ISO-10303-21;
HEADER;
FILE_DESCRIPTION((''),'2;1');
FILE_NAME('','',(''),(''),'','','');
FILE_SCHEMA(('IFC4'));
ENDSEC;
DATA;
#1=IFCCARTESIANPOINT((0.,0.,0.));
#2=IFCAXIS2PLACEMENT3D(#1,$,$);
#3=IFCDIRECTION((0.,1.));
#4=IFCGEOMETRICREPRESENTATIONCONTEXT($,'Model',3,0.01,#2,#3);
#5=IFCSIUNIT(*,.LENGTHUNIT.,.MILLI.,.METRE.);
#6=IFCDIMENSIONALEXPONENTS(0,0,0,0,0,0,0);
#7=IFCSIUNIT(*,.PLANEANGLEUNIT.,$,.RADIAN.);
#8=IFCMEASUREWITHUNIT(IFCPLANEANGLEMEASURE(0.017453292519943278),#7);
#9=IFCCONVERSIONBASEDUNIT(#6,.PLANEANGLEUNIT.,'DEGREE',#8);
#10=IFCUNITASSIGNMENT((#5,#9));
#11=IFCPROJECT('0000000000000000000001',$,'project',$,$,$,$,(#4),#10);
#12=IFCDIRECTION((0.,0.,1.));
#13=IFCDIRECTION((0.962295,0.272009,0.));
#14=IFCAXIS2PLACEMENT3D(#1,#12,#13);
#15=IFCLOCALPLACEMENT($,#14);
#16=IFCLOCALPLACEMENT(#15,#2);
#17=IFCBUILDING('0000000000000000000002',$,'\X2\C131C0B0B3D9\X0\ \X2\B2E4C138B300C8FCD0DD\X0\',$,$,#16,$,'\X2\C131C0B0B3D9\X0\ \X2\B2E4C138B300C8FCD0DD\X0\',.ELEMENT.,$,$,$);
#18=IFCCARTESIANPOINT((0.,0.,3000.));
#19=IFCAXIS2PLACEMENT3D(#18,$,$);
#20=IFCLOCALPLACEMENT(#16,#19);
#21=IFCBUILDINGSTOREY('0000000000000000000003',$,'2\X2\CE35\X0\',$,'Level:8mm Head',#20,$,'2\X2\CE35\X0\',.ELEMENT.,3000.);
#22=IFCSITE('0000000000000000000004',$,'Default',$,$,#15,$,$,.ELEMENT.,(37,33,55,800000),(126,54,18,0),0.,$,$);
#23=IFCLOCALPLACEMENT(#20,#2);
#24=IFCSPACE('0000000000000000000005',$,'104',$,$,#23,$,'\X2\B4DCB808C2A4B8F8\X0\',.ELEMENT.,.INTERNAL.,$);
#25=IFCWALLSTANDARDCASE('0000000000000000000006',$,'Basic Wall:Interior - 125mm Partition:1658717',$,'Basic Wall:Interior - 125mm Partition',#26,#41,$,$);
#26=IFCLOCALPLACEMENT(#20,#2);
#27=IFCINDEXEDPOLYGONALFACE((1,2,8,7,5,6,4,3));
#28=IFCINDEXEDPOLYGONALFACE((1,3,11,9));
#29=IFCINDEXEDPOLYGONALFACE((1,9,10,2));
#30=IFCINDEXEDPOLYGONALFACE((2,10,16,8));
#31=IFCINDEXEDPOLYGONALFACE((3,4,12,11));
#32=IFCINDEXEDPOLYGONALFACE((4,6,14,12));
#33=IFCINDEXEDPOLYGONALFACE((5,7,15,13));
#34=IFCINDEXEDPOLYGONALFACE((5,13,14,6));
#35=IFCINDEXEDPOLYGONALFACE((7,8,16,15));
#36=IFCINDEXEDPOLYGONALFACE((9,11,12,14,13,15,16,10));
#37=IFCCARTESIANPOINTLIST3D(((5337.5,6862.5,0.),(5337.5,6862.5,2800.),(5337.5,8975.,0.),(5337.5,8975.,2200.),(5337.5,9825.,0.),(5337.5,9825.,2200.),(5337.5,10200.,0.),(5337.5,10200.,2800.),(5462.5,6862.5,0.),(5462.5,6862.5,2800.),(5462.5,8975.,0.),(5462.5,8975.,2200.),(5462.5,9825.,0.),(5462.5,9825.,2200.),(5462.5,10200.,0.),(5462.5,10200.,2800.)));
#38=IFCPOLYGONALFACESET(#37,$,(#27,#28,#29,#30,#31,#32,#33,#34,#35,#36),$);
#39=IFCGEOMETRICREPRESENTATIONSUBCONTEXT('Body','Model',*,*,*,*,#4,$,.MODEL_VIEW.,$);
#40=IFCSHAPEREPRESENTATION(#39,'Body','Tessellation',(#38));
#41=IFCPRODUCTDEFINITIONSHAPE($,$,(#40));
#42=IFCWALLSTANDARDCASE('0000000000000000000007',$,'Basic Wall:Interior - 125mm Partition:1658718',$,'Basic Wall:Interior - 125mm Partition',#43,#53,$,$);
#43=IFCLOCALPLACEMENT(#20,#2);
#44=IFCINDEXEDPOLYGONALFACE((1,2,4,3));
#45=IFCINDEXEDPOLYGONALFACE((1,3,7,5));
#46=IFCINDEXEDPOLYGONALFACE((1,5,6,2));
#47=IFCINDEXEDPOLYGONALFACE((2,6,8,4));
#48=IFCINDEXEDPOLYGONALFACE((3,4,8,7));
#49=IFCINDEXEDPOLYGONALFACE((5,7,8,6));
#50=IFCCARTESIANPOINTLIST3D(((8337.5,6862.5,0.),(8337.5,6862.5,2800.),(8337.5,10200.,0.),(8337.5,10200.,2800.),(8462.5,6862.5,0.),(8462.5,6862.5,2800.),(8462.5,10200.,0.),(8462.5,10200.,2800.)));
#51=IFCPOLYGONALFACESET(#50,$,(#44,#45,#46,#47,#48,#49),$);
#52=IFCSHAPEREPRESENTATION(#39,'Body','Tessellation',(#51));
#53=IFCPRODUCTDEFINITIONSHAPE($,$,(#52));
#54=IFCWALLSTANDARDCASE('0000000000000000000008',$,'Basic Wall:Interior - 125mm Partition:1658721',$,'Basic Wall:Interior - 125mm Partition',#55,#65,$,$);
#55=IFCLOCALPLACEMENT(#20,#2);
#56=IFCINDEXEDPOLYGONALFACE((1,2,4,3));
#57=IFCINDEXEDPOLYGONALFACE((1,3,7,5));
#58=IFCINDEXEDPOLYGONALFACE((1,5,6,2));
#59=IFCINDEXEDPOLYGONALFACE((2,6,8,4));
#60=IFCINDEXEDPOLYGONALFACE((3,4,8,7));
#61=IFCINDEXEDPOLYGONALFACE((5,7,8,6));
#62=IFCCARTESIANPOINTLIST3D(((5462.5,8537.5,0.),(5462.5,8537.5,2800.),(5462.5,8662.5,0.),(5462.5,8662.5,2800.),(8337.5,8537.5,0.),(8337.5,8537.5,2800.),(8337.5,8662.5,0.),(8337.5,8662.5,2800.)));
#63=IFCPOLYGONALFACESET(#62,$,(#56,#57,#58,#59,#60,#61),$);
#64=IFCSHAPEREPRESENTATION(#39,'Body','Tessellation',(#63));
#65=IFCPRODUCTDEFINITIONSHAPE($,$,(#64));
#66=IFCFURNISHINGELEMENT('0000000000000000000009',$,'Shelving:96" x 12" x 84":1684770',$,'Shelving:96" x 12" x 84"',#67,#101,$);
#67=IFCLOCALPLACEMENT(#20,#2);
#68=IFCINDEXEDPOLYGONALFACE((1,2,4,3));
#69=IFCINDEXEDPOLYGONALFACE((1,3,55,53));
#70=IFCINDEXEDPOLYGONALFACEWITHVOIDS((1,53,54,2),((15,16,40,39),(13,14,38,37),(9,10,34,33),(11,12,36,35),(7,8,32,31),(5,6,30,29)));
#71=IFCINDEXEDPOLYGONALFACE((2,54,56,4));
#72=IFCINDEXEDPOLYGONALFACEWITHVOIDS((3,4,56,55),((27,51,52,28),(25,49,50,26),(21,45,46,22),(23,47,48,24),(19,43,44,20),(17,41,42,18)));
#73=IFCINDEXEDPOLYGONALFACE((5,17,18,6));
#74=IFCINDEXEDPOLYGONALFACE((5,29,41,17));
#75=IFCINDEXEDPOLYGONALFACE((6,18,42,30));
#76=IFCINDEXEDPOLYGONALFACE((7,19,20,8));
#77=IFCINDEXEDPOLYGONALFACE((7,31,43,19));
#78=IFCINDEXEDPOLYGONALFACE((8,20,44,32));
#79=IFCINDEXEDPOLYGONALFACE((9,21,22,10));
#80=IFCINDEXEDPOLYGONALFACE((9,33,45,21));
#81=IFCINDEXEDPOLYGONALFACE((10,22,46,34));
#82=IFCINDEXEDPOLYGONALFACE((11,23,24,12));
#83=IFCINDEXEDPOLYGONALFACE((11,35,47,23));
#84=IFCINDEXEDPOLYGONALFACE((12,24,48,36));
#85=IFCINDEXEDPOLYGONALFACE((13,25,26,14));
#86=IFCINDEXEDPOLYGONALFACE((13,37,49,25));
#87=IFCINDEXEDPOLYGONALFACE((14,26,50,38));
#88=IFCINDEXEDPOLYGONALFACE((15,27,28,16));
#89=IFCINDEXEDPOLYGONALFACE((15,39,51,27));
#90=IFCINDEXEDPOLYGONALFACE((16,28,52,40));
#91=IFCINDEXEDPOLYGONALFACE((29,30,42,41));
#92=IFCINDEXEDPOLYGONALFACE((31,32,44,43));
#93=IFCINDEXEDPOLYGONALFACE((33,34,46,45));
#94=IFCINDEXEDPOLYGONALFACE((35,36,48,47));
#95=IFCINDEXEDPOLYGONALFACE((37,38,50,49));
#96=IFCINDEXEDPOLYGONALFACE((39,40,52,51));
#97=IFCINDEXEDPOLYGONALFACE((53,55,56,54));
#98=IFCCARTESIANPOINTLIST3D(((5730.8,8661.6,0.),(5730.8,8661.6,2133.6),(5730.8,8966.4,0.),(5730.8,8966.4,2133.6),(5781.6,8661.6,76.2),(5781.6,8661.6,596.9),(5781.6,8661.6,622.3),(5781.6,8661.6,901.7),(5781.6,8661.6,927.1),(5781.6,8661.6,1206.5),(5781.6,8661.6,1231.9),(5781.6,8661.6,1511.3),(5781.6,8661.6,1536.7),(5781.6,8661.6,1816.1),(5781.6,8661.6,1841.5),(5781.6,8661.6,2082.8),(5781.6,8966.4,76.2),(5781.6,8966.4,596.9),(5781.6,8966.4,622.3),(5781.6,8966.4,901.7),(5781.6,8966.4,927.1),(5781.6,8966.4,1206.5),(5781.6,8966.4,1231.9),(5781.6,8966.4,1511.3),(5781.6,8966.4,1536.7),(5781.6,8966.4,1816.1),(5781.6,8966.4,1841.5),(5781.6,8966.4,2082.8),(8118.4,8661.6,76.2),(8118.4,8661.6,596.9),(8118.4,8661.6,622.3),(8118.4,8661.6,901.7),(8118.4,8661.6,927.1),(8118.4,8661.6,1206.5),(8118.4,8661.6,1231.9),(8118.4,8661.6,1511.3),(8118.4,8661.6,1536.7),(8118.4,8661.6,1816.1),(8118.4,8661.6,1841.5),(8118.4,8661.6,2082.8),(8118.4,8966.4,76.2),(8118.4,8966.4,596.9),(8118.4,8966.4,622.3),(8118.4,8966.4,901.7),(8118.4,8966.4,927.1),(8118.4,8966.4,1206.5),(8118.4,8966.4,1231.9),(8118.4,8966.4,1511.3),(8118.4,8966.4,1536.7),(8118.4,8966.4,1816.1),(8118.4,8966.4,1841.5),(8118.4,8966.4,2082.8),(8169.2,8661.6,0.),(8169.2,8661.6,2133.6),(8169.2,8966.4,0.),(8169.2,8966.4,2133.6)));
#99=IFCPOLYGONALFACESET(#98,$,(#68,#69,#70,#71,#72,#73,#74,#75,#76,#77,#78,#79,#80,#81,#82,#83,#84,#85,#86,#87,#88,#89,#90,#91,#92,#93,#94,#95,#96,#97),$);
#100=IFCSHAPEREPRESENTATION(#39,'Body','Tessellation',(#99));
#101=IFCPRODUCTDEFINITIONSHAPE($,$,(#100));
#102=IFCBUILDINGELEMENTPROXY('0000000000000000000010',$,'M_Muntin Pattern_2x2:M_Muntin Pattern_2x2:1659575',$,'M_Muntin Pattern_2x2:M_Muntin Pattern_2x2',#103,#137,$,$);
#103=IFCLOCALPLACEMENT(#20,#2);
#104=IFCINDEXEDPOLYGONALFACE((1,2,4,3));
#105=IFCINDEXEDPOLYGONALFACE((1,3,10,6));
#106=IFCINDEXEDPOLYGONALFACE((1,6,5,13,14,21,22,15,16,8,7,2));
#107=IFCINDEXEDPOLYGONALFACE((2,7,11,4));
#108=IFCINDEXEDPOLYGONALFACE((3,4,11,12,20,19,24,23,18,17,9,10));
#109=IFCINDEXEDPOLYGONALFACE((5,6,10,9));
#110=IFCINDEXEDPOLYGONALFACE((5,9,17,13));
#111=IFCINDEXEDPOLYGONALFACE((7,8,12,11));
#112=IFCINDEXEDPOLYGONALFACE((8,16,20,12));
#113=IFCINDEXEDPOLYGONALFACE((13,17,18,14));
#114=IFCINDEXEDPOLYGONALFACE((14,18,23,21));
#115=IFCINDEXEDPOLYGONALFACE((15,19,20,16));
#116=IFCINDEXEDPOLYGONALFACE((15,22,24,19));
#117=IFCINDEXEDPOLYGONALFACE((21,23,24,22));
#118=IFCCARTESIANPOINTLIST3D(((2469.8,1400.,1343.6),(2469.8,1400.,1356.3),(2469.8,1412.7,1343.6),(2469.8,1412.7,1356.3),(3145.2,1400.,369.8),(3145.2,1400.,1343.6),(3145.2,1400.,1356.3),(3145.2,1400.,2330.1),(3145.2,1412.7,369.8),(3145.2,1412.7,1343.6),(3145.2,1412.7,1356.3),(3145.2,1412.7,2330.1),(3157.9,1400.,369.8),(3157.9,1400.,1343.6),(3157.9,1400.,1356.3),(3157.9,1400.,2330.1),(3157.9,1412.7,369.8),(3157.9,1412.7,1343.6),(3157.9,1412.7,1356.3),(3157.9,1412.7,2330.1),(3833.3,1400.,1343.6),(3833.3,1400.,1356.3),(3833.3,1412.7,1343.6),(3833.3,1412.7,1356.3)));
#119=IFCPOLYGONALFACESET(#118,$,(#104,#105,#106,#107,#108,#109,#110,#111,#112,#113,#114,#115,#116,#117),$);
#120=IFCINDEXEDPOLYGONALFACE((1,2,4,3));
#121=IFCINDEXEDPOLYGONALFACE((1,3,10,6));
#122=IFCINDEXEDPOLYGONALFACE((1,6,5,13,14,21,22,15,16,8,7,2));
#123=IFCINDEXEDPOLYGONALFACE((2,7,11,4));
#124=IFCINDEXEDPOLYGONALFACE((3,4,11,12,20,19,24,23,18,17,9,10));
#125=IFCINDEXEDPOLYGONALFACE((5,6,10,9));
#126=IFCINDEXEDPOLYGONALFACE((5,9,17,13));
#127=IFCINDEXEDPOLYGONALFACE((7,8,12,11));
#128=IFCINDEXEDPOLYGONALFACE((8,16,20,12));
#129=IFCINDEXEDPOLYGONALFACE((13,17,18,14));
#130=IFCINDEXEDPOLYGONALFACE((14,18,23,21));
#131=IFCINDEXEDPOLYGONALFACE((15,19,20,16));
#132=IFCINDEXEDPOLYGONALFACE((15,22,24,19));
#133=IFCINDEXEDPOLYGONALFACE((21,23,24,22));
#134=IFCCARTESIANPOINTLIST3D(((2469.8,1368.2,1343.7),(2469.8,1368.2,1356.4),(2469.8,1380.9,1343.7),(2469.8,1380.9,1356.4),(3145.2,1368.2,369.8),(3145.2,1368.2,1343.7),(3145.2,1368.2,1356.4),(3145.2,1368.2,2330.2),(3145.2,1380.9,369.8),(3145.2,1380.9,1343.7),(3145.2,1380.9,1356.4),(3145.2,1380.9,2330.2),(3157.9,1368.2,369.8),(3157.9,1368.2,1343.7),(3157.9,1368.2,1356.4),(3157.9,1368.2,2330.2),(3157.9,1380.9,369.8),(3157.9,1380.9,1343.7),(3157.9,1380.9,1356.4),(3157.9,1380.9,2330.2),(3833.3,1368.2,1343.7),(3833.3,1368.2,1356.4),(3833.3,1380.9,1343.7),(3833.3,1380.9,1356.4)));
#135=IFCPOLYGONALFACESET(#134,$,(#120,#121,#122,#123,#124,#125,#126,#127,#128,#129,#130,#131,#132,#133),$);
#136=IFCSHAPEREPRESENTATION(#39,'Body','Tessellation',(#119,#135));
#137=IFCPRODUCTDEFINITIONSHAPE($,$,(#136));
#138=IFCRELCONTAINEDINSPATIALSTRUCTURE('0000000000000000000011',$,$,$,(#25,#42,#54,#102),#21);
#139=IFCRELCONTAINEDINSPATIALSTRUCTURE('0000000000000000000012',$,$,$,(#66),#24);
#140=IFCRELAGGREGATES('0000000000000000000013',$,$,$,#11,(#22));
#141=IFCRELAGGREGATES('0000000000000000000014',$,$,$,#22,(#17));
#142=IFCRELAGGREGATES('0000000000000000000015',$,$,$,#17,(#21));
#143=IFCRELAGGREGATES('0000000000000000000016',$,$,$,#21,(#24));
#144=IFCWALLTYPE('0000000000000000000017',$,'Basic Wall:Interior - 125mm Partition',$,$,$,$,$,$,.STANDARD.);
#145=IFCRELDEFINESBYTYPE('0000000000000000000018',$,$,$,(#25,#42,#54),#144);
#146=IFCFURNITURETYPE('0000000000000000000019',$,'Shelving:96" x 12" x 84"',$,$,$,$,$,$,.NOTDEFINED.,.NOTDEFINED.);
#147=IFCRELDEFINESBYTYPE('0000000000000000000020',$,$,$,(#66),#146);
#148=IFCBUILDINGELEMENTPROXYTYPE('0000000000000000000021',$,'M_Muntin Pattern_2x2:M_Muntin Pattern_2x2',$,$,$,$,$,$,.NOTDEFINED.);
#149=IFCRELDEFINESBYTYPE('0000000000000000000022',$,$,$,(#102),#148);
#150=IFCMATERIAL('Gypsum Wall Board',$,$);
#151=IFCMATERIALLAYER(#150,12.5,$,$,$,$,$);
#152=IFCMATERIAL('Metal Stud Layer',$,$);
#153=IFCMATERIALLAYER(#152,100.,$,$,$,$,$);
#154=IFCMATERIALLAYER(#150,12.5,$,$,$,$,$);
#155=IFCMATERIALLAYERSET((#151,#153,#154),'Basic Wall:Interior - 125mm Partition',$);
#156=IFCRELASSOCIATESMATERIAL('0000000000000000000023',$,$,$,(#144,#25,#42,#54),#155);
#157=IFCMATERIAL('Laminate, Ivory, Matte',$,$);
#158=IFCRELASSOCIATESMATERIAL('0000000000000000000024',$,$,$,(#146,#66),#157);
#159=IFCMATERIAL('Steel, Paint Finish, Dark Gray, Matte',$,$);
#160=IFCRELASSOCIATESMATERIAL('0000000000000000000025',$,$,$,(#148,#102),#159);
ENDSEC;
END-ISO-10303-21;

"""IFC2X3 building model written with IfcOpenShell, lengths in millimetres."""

from ifc_helpers import new_model, entity, si_unit, converted_unit, direction, frame, frame_2d, origin, place, context, subcontext, project, spatial, polyline, rectangle, outline, extrude, source, transform, mapped, material, layer, layer_set, layer_usage, type_object, type_shapes, element, save


model = new_model("IFC2X3")

# Units and contexts
model_context = context("Model", 3, precision=0.01, world=origin(), true_north=direction((0.0, 1.0)))
body_context = subcontext(model_context, "Body", "Model", "MODEL_VIEW")
ifc_project = project(units=[si_unit("LENGTHUNIT", "METRE", prefix="MILLI"), converted_unit("PLANEANGLEUNIT", "DEGREE", entity("IfcPlaneAngleMeasure", 0.017453292519943278), si_unit("PLANEANGLEUNIT", "RADIAN"), dimensions=[0, 0, 0, 0, 0, 0, 0])], contexts=[model_context])

# Site, building, storey
site_placement = place(None, frame((0.0, 0.0, 0.0), z_axis=(0.0, 0.0, 1.0), x_axis=(0.962295, 0.272009, 0.0)))
site = spatial("IfcSite", under=ifc_project, at=site_placement, Name="Default", CompositionType="ELEMENT", RefLatitude=(37, 33, 55, 800000), RefLongitude=(126, 54, 18, 0), RefElevation=0.0)
building_placement = place(site_placement, origin())
building = spatial("IfcBuilding", under=site, at=building_placement, Name="성산동 다세대주택", LongName="성산동 다세대주택", CompositionType="ELEMENT")
storey_placement = place(building_placement, frame((0.0, 0.0, 3000.0)))
storey = spatial("IfcBuildingStorey", under=building, at=storey_placement, Name="2층", ObjectType="Level:8mm Head", LongName="2층", CompositionType="ELEMENT", Elevation=3000.0)

# Wall, opening
ifc_material_1 = material(Name="Gypsum Wall Board")
ifc_layer_1 = layer(ifc_material_1, 12.5)
ifc_material_2 = material(Name="Metal Stud Layer")
ifc_layer_2 = layer(ifc_material_2, 100.0)
ifc_layer_3 = layer(ifc_material_1, 12.5)
ifc_layer_set = layer_set([ifc_layer_1, ifc_layer_2, ifc_layer_3], Name="Basic Wall:Interior - 125mm Partition")
ifc_layer_usage_1 = layer_usage(ifc_layer_set, "AXIS2", "NEGATIVE", 62.5)
wall_type = type_object("IfcWallType", Name="Basic Wall:Interior - 125mm Partition", PredefinedType="STANDARD", material=ifc_layer_set)
wall_1_placement = place(storey_placement, frame((5400.0, 6862.5, 0.0), z_axis=(0.0, 0.0, 1.0), x_axis=(0.0, 1.0, 0.0)))
wall_1 = element("IfcWallStandardCase", 1, at=wall_1_placement, inside=storey, type_object=wall_type, material=ifc_layer_usage_1, Name="Basic Wall:Interior - 125mm Partition:1658717", ObjectType="Basic Wall:Interior - 125mm Partition", context=body_context, shape_type="SweptSolid", body=[
    extrude(rectangle(XDim=3337.5, YDim=125.0, at=frame_2d((1668.7, 0.0), x_axis=(1.0, 0.0))), origin(), (0.0, 0.0, 1.0), 2800.0),
])
opening_placement = place(wall_1_placement, frame((2112.5, -62.5, 0.0)))
element("IfcOpeningElement", 2, at=opening_placement, cuts=wall_1, ObjectType="Opening", context=body_context, shape_type="SweptSolid", body=[
    extrude(rectangle(XDim=2200.0, YDim=850.0, at=frame_2d((1100.0, 425.0), x_axis=(1.0, 0.0))), frame((0.0, 0.0, 0.0), z_axis=(0.0, 1.0, 0.0), x_axis=(0.0, 0.0, 1.0)), (0.0, 0.0, 1.0), 125.0),
])

# Walls
ifc_layer_usage_2 = layer_usage(ifc_layer_set, "AXIS2", "NEGATIVE", 62.5)
wall_2_placement = place(storey_placement, frame((8400.0, 6862.5, 0.0), z_axis=(0.0, 0.0, 1.0), x_axis=(0.0, 1.0, 0.0)))
element("IfcWallStandardCase", 3, at=wall_2_placement, inside=storey, type_object=wall_type, material=ifc_layer_usage_2, Name="Basic Wall:Interior - 125mm Partition:1658718", ObjectType="Basic Wall:Interior - 125mm Partition", context=body_context, shape_type="SweptSolid", body=[
    extrude(rectangle(XDim=3337.5, YDim=125.0, at=frame_2d((1668.7, 0.0), x_axis=(-1.0, 0.0))), origin(), (0.0, 0.0, 1.0), 2800.0),
])
ifc_layer_usage_3 = layer_usage(ifc_layer_set, "AXIS2", "NEGATIVE", 62.5)
wall_3_placement = place(storey_placement, frame((5462.5, 8600.0, 0.0)))
element("IfcWallStandardCase", 4, at=wall_3_placement, inside=storey, type_object=wall_type, material=ifc_layer_usage_3, Name="Basic Wall:Interior - 125mm Partition:1658721", ObjectType="Basic Wall:Interior - 125mm Partition", context=body_context, shape_type="SweptSolid", body=[
    extrude(rectangle(XDim=2875.0, YDim=125.0, at=frame_2d((1437.5, 0.0), x_axis=(-1.0, 0.0))), origin(), (0.0, 0.0, 1.0), 2800.0),
])

# Shared definitions
space_1_placement = place(storey_placement, origin())
space_1 = spatial("IfcSpace", under=storey, at=space_1_placement, Name="104", LongName="드레스룸", CompositionType="ELEMENT", InteriorOrExteriorSpace="INTERNAL")

# Furnishing element
ifc_material_3 = material(Name="Laminate, Ivory, Matte")
furniture_type_1 = type_object("IfcFurnitureType", Name="Shelving:96\" x 12\" x 84\"", AssemblyPlace="NOTDEFINED", material=ifc_material_3)
shared_shape_1 = source(origin(), body_context, "Body", "SweptSolid", [
    extrude(outline(polyline([(-1219.2, -1066.8), (1219.2, -1066.8), (1219.2, 1066.8), (-1219.2, 1066.8), (-1219.2, -1066.8)]), holes=[polyline([(-1168.4, 1016.0), (1168.4, 1016.0), (1168.4, 774.7), (-1168.4, 774.7), (-1168.4, 1016.0)]), polyline([(-1168.4, -990.6), (-1168.4, -469.9), (1168.4, -469.9), (1168.4, -990.6), (-1168.4, -990.6)]), polyline([(1168.4, 165.1), (-1168.4, 165.1), (-1168.4, 444.5), (1168.4, 444.5), (1168.4, 165.1)]), polyline([(-1168.4, 749.3), (1168.4, 749.3), (1168.4, 469.9), (-1168.4, 469.9), (-1168.4, 749.3)]), polyline([(-1168.4, 139.7), (1168.4, 139.7), (1168.4, -139.7), (-1168.4, -139.7), (-1168.4, 139.7)]), polyline([(-1168.4, -165.1), (1168.4, -165.1), (1168.4, -444.5), (-1168.4, -444.5), (-1168.4, -165.1)])]), frame((0.0, -457.2, 1066.8), z_axis=(0.0, 1.0, 0.0), x_axis=(-1.0, 0.0, 0.0)), (0.0, 0.0, 1.0), 304.8),
])
type_shapes(furniture_type_1, [shared_shape_1])
furnishing_1_placement = place(space_1_placement, frame((6950.0, 8509.2, 0.0), z_axis=(0.0, 0.0, 1.0), x_axis=(-1.0, 0.0, 0.0)))
element("IfcFurnishingElement", 5, at=furnishing_1_placement, inside=space_1, type_object=furniture_type_1, material=ifc_material_3, Name="Shelving:96\" x 12\" x 84\":1684770", ObjectType="Shelving:96\" x 12\" x 84\"", context=body_context, shape_type="MappedRepresentation", body=[
    mapped(shared_shape_1, transform((0.0, 0.0, 0.0), scale=1.0)),
])

# Building element proxy
ifc_material_4 = material(Name="Steel, Paint Finish, Dark Gray, Matte")
building_element_proxy_type_1 = type_object("IfcBuildingElementProxyType", Name="M_Muntin Pattern_2x2:M_Muntin Pattern_2x2", PredefinedType="NOTDEFINED", material=ifc_material_4)
shared_shape_2 = source(origin(), body_context, "Body", "SweptSolid", [
    extrude(outline(polyline([(6.4, -6.4), (980.1, -6.4), (980.1, 6.3), (6.4, 6.3), (6.4, 681.7), (-6.3, 681.7), (-6.3, 6.3), (-980.2, 6.3), (-980.2, -6.4), (-6.3, -6.4), (-6.3, -681.7), (6.4, -681.7), (6.4, -6.4)])), frame((0.0, 9.5, 980.1), z_axis=(0.0, 1.0, 0.0), x_axis=(0.0, 0.0, 1.0)), (0.0, 0.0, 1.0), 12.7),
    extrude(outline(polyline([(6.4, -6.4), (980.2, -6.4), (980.2, 6.3), (6.4, 6.3), (6.4, 681.7), (-6.3, 681.7), (-6.3, 6.3), (-980.2, 6.3), (-980.2, -6.4), (-6.3, -6.4), (-6.3, -681.7), (6.4, -681.7), (6.4, -6.4)])), frame((0.0, -22.2, 980.2), z_axis=(0.0, 1.0, 0.0), x_axis=(0.0, 0.0, 1.0)), (0.0, 0.0, 1.0), 12.7),
])
type_shapes(building_element_proxy_type_1, [shared_shape_2])
proxy_1_placement = place(storey_placement, frame((3151.6, 1390.5, 369.8)))
element("IfcBuildingElementProxy", 6, at=proxy_1_placement, inside=storey, type_object=building_element_proxy_type_1, material=ifc_material_4, Name="M_Muntin Pattern_2x2:M_Muntin Pattern_2x2:1659575", ObjectType="M_Muntin Pattern_2x2:M_Muntin Pattern_2x2", context=body_context, shape_type="MappedRepresentation", body=[
    mapped(shared_shape_2, transform((0.0, 0.0, 0.0), scale=1.0)),
])

save(model, "model.ifc")
